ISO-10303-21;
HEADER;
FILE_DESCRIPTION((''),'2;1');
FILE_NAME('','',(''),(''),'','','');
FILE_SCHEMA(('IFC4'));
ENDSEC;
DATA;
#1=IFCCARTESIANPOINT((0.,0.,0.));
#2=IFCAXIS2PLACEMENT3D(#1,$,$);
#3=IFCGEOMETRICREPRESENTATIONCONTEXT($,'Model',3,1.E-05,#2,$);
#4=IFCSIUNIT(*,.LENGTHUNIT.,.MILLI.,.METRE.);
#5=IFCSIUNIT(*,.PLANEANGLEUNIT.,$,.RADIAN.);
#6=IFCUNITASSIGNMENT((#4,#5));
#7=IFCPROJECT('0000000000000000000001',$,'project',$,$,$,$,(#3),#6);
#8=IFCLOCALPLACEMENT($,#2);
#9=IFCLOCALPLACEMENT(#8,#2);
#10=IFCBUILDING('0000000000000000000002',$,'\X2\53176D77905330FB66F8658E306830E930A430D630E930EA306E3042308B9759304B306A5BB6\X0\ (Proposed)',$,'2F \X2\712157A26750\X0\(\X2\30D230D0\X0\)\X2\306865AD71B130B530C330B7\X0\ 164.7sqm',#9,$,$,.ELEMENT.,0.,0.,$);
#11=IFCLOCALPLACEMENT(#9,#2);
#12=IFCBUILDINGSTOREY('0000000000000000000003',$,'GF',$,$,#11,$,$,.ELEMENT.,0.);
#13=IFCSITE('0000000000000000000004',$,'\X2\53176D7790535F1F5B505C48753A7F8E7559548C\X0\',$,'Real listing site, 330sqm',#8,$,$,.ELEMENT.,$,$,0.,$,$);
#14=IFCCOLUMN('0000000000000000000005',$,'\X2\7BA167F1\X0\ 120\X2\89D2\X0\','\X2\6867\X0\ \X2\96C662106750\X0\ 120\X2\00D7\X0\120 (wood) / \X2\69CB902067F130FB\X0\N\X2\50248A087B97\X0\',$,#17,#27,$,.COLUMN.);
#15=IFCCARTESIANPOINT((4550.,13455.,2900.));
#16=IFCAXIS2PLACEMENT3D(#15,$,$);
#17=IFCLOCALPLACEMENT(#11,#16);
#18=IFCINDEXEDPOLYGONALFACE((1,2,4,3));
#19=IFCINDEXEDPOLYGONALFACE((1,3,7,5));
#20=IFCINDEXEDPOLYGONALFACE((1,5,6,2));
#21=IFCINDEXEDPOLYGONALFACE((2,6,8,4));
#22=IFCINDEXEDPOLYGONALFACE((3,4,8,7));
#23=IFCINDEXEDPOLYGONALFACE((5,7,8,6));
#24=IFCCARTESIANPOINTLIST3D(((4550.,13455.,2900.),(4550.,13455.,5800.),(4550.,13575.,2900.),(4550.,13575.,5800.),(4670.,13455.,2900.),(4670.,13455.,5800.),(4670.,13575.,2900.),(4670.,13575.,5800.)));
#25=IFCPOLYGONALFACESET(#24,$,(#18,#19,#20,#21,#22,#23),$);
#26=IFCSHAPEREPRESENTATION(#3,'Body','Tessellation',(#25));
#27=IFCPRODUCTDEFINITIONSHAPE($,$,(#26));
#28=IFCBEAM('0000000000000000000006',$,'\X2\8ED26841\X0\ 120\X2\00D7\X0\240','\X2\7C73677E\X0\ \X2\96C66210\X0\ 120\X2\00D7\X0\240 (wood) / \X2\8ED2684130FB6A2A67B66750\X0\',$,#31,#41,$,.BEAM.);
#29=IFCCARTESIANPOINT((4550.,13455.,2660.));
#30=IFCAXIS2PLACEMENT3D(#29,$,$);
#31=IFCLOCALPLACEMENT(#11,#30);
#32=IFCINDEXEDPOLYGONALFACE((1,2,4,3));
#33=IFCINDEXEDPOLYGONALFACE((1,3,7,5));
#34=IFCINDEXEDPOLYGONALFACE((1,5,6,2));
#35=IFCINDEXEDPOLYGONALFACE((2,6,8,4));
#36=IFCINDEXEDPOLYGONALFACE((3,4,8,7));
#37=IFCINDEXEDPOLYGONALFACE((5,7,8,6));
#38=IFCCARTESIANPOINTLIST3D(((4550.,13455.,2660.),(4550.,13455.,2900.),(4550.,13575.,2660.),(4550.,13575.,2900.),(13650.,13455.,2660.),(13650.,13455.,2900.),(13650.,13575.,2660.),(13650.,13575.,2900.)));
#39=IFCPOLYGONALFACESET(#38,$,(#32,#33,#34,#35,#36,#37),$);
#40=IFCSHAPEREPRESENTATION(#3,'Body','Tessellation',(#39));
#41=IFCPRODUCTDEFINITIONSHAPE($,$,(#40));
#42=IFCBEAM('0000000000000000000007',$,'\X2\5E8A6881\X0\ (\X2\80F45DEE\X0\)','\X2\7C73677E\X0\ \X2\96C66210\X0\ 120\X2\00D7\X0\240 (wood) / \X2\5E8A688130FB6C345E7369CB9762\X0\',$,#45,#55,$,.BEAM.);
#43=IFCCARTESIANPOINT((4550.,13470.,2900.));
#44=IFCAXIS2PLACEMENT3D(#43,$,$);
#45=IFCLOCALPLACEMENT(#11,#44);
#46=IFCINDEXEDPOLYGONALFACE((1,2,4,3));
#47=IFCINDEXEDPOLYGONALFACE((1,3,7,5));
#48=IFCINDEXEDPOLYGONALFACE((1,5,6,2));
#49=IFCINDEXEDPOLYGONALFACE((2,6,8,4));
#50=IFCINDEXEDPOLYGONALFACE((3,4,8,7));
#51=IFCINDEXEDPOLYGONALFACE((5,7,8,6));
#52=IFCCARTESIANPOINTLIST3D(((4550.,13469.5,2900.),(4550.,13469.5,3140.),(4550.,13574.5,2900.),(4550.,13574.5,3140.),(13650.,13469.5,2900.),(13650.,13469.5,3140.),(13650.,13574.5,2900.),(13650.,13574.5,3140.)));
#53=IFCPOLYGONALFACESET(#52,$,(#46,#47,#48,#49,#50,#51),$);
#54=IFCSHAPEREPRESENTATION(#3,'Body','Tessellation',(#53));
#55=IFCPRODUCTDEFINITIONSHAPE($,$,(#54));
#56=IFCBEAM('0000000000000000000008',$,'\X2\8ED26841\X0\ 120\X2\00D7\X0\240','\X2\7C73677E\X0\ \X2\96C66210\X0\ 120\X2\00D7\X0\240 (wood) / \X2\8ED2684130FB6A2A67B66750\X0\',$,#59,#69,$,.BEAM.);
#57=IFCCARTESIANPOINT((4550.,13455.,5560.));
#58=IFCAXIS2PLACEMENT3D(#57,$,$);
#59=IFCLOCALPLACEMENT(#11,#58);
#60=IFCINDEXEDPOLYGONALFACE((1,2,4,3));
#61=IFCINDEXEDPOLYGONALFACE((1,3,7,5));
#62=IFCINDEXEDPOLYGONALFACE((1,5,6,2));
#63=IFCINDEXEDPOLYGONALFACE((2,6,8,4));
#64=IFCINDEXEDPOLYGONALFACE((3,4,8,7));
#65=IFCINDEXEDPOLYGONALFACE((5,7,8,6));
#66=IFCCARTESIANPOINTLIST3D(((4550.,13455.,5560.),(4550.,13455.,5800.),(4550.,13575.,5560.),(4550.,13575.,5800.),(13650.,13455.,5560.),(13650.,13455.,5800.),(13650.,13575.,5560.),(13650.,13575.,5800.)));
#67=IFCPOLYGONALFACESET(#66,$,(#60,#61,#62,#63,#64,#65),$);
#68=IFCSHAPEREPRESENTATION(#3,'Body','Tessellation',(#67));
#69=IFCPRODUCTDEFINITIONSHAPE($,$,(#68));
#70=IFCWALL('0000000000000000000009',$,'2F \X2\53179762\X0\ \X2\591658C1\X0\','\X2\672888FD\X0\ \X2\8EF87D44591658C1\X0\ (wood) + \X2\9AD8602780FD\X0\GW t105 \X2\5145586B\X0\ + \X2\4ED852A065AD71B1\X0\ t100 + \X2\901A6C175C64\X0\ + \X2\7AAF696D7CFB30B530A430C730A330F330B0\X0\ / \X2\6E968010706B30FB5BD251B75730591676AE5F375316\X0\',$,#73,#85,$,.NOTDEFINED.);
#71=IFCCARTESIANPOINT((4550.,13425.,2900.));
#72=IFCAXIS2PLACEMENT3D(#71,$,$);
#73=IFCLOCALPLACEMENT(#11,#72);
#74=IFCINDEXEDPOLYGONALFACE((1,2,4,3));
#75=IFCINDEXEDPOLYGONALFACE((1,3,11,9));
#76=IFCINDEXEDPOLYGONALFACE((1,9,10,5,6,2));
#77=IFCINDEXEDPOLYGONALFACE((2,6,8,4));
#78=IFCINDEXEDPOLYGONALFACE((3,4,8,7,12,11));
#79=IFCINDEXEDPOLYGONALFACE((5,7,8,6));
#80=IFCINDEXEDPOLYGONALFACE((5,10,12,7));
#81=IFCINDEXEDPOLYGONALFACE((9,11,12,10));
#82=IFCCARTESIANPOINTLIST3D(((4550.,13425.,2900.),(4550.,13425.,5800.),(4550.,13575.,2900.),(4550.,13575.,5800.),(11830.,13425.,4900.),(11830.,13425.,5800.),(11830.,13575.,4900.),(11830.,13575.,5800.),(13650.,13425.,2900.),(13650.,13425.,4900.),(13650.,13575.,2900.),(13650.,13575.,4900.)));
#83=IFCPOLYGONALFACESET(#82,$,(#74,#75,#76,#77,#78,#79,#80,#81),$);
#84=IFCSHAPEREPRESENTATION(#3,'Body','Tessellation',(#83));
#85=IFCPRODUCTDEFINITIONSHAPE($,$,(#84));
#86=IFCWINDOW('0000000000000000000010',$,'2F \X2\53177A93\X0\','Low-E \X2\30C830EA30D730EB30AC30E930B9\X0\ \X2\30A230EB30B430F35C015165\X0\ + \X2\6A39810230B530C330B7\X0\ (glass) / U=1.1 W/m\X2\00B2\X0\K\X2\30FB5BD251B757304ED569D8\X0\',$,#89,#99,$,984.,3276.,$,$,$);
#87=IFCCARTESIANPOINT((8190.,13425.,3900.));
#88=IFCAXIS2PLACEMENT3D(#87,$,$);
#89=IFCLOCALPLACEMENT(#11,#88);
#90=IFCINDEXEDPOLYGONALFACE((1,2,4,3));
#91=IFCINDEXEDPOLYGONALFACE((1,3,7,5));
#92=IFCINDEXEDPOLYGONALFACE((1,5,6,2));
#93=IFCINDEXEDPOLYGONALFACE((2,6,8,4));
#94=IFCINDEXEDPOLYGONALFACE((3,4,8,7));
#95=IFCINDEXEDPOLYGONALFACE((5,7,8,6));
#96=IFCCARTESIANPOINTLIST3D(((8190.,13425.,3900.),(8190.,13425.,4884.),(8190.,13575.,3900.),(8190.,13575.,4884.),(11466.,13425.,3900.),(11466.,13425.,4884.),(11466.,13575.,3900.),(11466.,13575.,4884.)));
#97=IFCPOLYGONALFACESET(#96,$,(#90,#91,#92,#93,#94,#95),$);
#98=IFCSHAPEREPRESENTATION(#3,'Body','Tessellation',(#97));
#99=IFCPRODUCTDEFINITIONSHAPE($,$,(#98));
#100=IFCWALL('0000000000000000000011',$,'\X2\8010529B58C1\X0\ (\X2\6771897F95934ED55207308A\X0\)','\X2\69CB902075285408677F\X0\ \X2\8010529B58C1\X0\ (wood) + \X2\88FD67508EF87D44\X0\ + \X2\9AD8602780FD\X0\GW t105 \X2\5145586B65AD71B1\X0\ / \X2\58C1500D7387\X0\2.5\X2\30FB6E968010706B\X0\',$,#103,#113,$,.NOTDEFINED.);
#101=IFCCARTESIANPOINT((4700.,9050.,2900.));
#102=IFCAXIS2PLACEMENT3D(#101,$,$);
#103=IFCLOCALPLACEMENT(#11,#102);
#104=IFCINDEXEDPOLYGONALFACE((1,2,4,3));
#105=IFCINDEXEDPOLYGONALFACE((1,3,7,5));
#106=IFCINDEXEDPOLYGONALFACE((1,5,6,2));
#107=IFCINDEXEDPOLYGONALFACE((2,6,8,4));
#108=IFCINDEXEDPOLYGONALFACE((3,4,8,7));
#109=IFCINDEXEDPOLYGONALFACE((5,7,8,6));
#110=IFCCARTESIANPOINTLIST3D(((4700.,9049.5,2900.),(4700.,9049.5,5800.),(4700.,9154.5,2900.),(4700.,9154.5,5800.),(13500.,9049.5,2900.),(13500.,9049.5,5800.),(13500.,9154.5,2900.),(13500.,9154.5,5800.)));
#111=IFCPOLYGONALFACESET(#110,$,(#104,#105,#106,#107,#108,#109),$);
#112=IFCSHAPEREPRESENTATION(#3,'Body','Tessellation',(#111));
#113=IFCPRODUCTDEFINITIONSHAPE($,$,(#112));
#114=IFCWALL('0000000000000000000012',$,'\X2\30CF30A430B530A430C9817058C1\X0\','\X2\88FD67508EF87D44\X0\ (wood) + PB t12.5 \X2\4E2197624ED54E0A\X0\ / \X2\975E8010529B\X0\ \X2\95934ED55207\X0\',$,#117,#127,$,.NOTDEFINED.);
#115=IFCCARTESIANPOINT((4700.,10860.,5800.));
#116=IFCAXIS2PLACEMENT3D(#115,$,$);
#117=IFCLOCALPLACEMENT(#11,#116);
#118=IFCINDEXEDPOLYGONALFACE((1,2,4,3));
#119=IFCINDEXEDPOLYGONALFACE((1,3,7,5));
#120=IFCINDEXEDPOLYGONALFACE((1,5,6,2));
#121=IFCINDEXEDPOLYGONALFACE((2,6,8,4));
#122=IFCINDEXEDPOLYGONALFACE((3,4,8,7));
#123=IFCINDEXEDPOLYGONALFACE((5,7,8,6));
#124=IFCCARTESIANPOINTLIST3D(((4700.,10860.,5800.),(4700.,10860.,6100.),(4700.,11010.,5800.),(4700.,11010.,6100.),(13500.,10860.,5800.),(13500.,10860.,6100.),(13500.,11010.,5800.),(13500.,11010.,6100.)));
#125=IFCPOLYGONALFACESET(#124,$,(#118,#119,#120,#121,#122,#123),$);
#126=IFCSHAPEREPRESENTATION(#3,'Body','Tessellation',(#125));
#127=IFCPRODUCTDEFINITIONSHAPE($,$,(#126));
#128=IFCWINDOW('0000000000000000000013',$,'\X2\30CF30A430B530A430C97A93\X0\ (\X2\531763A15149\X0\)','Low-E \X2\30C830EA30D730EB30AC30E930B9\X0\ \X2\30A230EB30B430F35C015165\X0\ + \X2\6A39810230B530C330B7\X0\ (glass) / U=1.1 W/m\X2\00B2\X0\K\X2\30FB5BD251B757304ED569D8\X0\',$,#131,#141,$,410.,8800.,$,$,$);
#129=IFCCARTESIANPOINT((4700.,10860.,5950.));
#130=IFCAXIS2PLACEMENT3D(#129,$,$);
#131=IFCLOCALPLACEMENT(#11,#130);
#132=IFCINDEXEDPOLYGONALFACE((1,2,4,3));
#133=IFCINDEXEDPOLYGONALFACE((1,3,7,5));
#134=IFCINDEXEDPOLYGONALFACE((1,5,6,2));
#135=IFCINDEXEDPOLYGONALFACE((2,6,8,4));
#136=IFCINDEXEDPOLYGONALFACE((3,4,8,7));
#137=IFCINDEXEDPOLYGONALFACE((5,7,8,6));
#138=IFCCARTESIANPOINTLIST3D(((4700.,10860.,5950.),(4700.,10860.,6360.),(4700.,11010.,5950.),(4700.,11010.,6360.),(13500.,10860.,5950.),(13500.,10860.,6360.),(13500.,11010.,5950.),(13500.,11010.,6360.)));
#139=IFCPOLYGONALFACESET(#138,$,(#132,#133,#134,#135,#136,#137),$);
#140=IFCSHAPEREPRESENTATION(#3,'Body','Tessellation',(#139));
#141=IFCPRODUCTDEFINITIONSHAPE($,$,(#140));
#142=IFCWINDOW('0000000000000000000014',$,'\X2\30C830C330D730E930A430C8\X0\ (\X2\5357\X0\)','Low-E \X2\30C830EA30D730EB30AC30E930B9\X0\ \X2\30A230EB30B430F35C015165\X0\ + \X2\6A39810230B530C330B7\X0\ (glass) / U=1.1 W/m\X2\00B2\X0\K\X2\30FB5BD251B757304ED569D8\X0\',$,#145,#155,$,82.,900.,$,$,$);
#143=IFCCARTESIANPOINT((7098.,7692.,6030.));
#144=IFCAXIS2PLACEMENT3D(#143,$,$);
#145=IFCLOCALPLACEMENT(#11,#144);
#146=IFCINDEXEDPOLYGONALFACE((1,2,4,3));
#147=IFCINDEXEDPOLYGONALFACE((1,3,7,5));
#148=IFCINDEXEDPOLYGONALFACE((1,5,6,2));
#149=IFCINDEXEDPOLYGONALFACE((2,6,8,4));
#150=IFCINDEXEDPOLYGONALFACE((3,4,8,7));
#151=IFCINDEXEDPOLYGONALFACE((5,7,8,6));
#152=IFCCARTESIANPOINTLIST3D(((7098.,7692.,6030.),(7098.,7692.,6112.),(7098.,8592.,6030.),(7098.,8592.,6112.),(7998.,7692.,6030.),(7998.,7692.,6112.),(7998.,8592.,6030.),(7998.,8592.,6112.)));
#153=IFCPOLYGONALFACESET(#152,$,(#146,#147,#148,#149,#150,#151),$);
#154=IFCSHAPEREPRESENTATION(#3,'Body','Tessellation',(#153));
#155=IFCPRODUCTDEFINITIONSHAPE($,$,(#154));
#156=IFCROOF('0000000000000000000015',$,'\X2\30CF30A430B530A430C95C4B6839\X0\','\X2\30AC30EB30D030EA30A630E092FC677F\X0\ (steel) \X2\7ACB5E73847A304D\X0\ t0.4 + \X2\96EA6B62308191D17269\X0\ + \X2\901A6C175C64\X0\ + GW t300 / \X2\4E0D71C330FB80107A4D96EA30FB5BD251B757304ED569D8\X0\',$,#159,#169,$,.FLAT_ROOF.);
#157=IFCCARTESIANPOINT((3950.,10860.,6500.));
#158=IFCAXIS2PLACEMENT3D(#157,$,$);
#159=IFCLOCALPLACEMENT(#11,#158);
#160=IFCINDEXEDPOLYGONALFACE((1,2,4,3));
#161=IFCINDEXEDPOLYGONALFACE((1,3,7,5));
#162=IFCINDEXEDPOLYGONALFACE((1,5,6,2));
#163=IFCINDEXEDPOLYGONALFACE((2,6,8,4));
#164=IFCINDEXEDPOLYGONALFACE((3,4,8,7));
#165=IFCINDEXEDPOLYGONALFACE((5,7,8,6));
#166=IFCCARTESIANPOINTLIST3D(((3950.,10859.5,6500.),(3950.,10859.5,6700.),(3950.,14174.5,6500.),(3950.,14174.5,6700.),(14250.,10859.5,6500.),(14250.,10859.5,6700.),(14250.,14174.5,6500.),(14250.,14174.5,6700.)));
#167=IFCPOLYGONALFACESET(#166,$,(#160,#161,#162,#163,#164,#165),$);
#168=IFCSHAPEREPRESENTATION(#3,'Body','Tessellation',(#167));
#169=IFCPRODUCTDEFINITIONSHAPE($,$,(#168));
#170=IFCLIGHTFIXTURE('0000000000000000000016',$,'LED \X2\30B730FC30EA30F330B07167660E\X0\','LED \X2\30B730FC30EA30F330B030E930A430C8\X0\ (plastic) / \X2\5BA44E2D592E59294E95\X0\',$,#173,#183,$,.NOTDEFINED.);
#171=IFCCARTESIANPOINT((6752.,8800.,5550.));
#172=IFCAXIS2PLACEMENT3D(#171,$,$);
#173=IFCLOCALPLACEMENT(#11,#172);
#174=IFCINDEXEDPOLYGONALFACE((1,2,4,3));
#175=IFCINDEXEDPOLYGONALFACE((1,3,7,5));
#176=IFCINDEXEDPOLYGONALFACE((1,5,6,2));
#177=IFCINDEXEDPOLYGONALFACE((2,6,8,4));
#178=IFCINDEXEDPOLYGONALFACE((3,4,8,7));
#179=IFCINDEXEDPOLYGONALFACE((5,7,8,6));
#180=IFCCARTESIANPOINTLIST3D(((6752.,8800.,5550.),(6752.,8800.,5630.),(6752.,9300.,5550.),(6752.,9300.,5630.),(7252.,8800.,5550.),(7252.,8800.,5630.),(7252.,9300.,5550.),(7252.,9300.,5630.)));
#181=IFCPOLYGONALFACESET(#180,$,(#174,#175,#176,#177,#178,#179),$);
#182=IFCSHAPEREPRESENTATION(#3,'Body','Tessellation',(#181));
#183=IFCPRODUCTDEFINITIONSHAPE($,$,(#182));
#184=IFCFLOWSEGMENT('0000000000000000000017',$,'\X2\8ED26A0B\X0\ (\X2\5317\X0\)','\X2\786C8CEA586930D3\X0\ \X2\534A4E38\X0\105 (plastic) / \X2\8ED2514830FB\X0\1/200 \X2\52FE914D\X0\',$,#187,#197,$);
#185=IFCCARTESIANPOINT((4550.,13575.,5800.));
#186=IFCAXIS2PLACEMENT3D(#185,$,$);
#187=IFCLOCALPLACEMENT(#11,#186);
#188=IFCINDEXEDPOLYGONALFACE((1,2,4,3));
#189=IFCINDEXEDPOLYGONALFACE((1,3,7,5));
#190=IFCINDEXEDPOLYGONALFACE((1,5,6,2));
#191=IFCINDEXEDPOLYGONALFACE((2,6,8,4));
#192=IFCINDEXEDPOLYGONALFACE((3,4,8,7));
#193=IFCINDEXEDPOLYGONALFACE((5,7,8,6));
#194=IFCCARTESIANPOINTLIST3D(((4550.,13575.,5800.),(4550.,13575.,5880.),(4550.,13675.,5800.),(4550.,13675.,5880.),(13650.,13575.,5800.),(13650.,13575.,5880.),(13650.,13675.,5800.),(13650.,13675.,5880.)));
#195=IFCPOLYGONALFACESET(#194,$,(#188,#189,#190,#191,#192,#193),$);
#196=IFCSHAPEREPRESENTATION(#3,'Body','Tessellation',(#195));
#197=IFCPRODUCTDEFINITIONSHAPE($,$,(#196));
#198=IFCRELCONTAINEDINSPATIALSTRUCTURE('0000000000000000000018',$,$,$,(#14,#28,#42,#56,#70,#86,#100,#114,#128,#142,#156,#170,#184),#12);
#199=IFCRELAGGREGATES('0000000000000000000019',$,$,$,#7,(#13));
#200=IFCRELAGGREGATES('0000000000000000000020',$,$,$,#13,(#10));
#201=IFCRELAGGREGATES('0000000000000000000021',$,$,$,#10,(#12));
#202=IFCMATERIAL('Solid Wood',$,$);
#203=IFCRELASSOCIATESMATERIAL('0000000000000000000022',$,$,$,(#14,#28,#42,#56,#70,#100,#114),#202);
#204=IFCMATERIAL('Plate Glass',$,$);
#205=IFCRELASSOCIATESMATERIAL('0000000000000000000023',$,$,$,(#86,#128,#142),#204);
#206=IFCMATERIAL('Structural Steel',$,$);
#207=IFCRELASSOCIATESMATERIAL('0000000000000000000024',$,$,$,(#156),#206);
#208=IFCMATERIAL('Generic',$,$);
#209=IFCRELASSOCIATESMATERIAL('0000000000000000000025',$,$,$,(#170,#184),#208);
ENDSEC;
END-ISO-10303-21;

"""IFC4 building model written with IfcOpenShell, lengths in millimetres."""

from ifc_helpers import new_model, si_unit, frame, frame_2d, origin, place, context, project, spatial, rectangle, extrude, material, element, fill, save


model = new_model("IFC4")

# Units and contexts
model_context = context("Model", 3, precision=1e-05, world=origin())
ifc_project = project(units=[si_unit("LENGTHUNIT", "METRE", prefix="MILLI"), si_unit("PLANEANGLEUNIT", "RADIAN")], contexts=[model_context])

# Site, building, storey
site_placement = place(None, origin())
site = spatial("IfcSite", under=ifc_project, at=site_placement, Name="北海道弟子屈町美留和", ObjectType="Real listing site, 330sqm", CompositionType="ELEMENT", RefElevation=0.0)
building_placement = place(site_placement, origin())
building = spatial("IfcBuilding", under=site, at=building_placement, Name="北海道・書斎とライブラリのある静かな家 (Proposed)", ObjectType="2F 無垢材(ヒバ)と断熱サッシ 164.7sqm", CompositionType="ELEMENT", ElevationOfRefHeight=0.0, ElevationOfTerrain=0.0)
storey_placement = place(building_placement, origin())
storey = spatial("IfcBuildingStorey", under=building, at=storey_placement, Name="GF", CompositionType="ELEMENT", Elevation=0.0)

# Column
ifc_material_1 = material(Name="Solid Wood")
column_1_placement = place(storey_placement, frame((4550.0, 13455.0, 2900.0)))
element("IfcColumn", 1, at=column_1_placement, inside=storey, material=ifc_material_1, Name="管柱 120角", Description="桧 集成材 120×120 (wood) / 構造柱・N値計算", PredefinedType="COLUMN", context=model_context, shape_type="SweptSolid", body=[
    extrude(rectangle(XDim=120.0, YDim=120.0, at=frame_2d((60.0, 60.0))), frame((4550.0, 13455.0, 2900.0)), (0.0, 0.0, 1.0), 2900.0),
])

# Beams
beam_1_placement = place(storey_placement, frame((4550.0, 13455.0, 2660.0)))
element("IfcBeam", 2, at=beam_1_placement, inside=storey, material=ifc_material_1, Name="軒桁 120×240", Description="米松 集成 120×240 (wood) / 軒桁・横架材", PredefinedType="BEAM", context=model_context, shape_type="SweptSolid", body=[
    extrude(rectangle(XDim=9100.0, YDim=120.0, at=frame_2d((4550.0, 60.0))), frame((4550.0, 13455.0, 2660.0)), (0.0, 0.0, 1.0), 240.0),
])
beam_2_placement = place(storey_placement, frame((4550.0, 13470.0, 2900.0)))
element("IfcBeam", 3, at=beam_2_placement, inside=storey, material=ifc_material_1, Name="床梁 (胴差)", Description="米松 集成 120×240 (wood) / 床梁・水平構面", PredefinedType="BEAM", context=model_context, shape_type="SweptSolid", body=[
    extrude(rectangle(XDim=9100.0, YDim=105.0, at=frame_2d((4550.0, 52.0))), frame((4550.0, 13470.0, 2900.0)), (0.0, 0.0, 1.0), 240.0),
])
beam_3_placement = place(storey_placement, frame((4550.0, 13455.0, 5560.0)))
element("IfcBeam", 4, at=beam_3_placement, inside=storey, material=ifc_material_1, Name="軒桁 120×240", Description="米松 集成 120×240 (wood) / 軒桁・横架材", PredefinedType="BEAM", context=model_context, shape_type="SweptSolid", body=[
    extrude(rectangle(XDim=9100.0, YDim=120.0, at=frame_2d((4550.0, 60.0))), frame((4550.0, 13455.0, 5560.0)), (0.0, 0.0, 1.0), 240.0),
])

# Wall, opening, window
wall_1_placement = place(storey_placement, frame((4550.0, 13425.0, 2900.0)))
wall_1 = element("IfcWall", 5, at=wall_1_placement, inside=storey, material=ifc_material_1, Name="2F 北面 外壁", Description="木製 軸組外壁 (wood) + 高性能GW t105 充填 + 付加断熱 t100 + 通気層 + 窯業系サイディング / 準耐火・寒冷地外皮強化", PredefinedType="NOTDEFINED", context=model_context, shape_type="SweptSolid", body=[
    extrude(rectangle(XDim=9100.0, YDim=150.0, at=frame_2d((4550.0, 75.0))), frame((4550.0, 13425.0, 2900.0)), (0.0, 0.0, 1.0), 2900.0),
])
opening_1_placement = place(storey_placement, frame((8190.0, 13425.0, 3900.0)))
opening_1 = element("IfcOpeningElement", 6, at=opening_1_placement, cuts=wall_1, PredefinedType="NOTDEFINED", context=model_context, shape_type="SweptSolid", body=[
    extrude(rectangle(XDim=3276.0, YDim=150.0, at=frame_2d((1638.0, 75.0))), frame((8190.0, 13425.0, 3900.0)), (0.0, 0.0, 1.0), 984.0),
])
ifc_material_2 = material(Name="Plate Glass")
window_1_placement = place(storey_placement, frame((8190.0, 13425.0, 3900.0)))
window_1 = element("IfcWindow", 7, at=window_1_placement, inside=storey, material=ifc_material_2, Name="2F 北窓", Description="Low-E トリプルガラス アルゴン封入 + 樹脂サッシ (glass) / U=1.1 W/m²K・寒冷地仕様", OverallHeight=984.0, OverallWidth=3276.0, context=model_context, shape_type="SweptSolid", body=[
    extrude(rectangle(XDim=3276.0, YDim=150.0, at=frame_2d((1638.0, 75.0))), frame((8190.0, 13425.0, 3900.0)), (0.0, 0.0, 1.0), 984.0),
])
fill(opening_1, window_1)

# Wall
wall_2_placement = place(storey_placement, frame((4700.0, 9050.0, 2900.0)))
element("IfcWall", 8, at=wall_2_placement, inside=storey, material=ifc_material_1, Name="耐力壁 (東西間仕切り)", Description="構造用合板 耐力壁 (wood) + 製材軸組 + 高性能GW t105 充填断熱 / 壁倍率2.5・準耐火", PredefinedType="NOTDEFINED", context=model_context, shape_type="SweptSolid", body=[
    extrude(rectangle(XDim=8800.0, YDim=105.0, at=frame_2d((4400.0, 52.0))), frame((4700.0, 9050.0, 2900.0)), (0.0, 0.0, 1.0), 2900.0),
])

# Wall, opening, window
wall_3_placement = place(storey_placement, frame((4700.0, 10860.0, 5800.0)))
wall_3 = element("IfcWall", 9, at=wall_3_placement, inside=storey, material=ifc_material_1, Name="ハイサイド腰壁", Description="製材軸組 (wood) + PB t12.5 両面仕上 / 非耐力 間仕切", PredefinedType="NOTDEFINED", context=model_context, shape_type="SweptSolid", body=[
    extrude(rectangle(XDim=8800.0, YDim=150.0, at=frame_2d((4400.0, 75.0))), frame((4700.0, 10860.0, 5800.0)), (0.0, 0.0, 1.0), 700.0),
])
opening_2_placement = place(storey_placement, frame((4700.0, 10860.0, 5950.0)))
opening_2 = element("IfcOpeningElement", 10, at=opening_2_placement, cuts=wall_3, PredefinedType="NOTDEFINED", context=model_context, shape_type="SweptSolid", body=[
    extrude(rectangle(XDim=8800.0, YDim=150.0, at=frame_2d((4400.0, 75.0))), frame((4700.0, 10860.0, 5950.0)), (0.0, 0.0, 1.0), 410.0),
])
window_2_placement = place(storey_placement, frame((4700.0, 10860.0, 5950.0)))
window_2 = element("IfcWindow", 11, at=window_2_placement, inside=storey, material=ifc_material_2, Name="ハイサイド窓 (北採光)", Description="Low-E トリプルガラス アルゴン封入 + 樹脂サッシ (glass) / U=1.1 W/m²K・寒冷地仕様", OverallHeight=410.0, OverallWidth=8800.0, context=model_context, shape_type="SweptSolid", body=[
    extrude(rectangle(XDim=8800.0, YDim=150.0, at=frame_2d((4400.0, 75.0))), frame((4700.0, 10860.0, 5950.0)), (0.0, 0.0, 1.0), 410.0),
])
fill(opening_2, window_2)

# Window
window_3_placement = place(storey_placement, frame((7098.0, 7692.0, 6030.0)))
element("IfcWindow", 12, at=window_3_placement, inside=storey, material=ifc_material_2, Name="トップライト (南)", Description="Low-E トリプルガラス アルゴン封入 + 樹脂サッシ (glass) / U=1.1 W/m²K・寒冷地仕様", OverallHeight=82.0, OverallWidth=900.0, context=model_context, shape_type="SweptSolid", body=[
    extrude(rectangle(XDim=900.0, YDim=900.0, at=frame_2d((450.0, 450.0))), frame((7098.0, 7692.0, 6030.0)), (0.0, 0.0, 1.0), 82.0),
])

# Roof
ifc_material_3 = material(Name="Structural Steel")
roof_placement = place(storey_placement, frame((3950.0, 10860.0, 6500.0)))
element("IfcRoof", 13, at=roof_placement, inside=storey, material=ifc_material_3, Name="ハイサイド屋根", Description="ガルバリウム鋼板 (steel) 立平葺き t0.4 + 雪止め金物 + 通気層 + GW t300 / 不燃・耐積雪・寒冷地仕様", PredefinedType="FLAT_ROOF", context=model_context, shape_type="SweptSolid", body=[
    extrude(rectangle(XDim=10300.0, YDim=3315.0, at=frame_2d((5150.0, 1657.0))), frame((3950.0, 10860.0, 6500.0)), (0.0, 0.0, 1.0), 200.0),
])

# Light fixture
ifc_material_4 = material(Name="Generic")
light_fixture_placement = place(storey_placement, frame((6752.0, 8800.0, 5550.0)))
element("IfcLightFixture", 14, at=light_fixture_placement, inside=storey, material=ifc_material_4, Name="LED シーリング照明", Description="LED シーリングライト (plastic) / 室中央天井", PredefinedType="NOTDEFINED", context=model_context, shape_type="SweptSolid", body=[
    extrude(rectangle(XDim=500.0, YDim=500.0, at=frame_2d((250.0, 250.0))), frame((6752.0, 8800.0, 5550.0)), (0.0, 0.0, 1.0), 80.0),
])

# Flow segment
flow_segment_placement = place(storey_placement, frame((4550.0, 13575.0, 5800.0)))
element("IfcFlowSegment", 15, at=flow_segment_placement, inside=storey, material=ifc_material_4, Name="軒樋 (北)", Description="硬質塩ビ 半丸105 (plastic) / 軒先・1/200 勾配", context=model_context, shape_type="SweptSolid", body=[
    extrude(rectangle(XDim=9100.0, YDim=100.0, at=frame_2d((4550.0, 50.0))), frame((4550.0, 13575.0, 5800.0)), (0.0, 0.0, 1.0), 80.0),
])

save(model, "model.ifc")
